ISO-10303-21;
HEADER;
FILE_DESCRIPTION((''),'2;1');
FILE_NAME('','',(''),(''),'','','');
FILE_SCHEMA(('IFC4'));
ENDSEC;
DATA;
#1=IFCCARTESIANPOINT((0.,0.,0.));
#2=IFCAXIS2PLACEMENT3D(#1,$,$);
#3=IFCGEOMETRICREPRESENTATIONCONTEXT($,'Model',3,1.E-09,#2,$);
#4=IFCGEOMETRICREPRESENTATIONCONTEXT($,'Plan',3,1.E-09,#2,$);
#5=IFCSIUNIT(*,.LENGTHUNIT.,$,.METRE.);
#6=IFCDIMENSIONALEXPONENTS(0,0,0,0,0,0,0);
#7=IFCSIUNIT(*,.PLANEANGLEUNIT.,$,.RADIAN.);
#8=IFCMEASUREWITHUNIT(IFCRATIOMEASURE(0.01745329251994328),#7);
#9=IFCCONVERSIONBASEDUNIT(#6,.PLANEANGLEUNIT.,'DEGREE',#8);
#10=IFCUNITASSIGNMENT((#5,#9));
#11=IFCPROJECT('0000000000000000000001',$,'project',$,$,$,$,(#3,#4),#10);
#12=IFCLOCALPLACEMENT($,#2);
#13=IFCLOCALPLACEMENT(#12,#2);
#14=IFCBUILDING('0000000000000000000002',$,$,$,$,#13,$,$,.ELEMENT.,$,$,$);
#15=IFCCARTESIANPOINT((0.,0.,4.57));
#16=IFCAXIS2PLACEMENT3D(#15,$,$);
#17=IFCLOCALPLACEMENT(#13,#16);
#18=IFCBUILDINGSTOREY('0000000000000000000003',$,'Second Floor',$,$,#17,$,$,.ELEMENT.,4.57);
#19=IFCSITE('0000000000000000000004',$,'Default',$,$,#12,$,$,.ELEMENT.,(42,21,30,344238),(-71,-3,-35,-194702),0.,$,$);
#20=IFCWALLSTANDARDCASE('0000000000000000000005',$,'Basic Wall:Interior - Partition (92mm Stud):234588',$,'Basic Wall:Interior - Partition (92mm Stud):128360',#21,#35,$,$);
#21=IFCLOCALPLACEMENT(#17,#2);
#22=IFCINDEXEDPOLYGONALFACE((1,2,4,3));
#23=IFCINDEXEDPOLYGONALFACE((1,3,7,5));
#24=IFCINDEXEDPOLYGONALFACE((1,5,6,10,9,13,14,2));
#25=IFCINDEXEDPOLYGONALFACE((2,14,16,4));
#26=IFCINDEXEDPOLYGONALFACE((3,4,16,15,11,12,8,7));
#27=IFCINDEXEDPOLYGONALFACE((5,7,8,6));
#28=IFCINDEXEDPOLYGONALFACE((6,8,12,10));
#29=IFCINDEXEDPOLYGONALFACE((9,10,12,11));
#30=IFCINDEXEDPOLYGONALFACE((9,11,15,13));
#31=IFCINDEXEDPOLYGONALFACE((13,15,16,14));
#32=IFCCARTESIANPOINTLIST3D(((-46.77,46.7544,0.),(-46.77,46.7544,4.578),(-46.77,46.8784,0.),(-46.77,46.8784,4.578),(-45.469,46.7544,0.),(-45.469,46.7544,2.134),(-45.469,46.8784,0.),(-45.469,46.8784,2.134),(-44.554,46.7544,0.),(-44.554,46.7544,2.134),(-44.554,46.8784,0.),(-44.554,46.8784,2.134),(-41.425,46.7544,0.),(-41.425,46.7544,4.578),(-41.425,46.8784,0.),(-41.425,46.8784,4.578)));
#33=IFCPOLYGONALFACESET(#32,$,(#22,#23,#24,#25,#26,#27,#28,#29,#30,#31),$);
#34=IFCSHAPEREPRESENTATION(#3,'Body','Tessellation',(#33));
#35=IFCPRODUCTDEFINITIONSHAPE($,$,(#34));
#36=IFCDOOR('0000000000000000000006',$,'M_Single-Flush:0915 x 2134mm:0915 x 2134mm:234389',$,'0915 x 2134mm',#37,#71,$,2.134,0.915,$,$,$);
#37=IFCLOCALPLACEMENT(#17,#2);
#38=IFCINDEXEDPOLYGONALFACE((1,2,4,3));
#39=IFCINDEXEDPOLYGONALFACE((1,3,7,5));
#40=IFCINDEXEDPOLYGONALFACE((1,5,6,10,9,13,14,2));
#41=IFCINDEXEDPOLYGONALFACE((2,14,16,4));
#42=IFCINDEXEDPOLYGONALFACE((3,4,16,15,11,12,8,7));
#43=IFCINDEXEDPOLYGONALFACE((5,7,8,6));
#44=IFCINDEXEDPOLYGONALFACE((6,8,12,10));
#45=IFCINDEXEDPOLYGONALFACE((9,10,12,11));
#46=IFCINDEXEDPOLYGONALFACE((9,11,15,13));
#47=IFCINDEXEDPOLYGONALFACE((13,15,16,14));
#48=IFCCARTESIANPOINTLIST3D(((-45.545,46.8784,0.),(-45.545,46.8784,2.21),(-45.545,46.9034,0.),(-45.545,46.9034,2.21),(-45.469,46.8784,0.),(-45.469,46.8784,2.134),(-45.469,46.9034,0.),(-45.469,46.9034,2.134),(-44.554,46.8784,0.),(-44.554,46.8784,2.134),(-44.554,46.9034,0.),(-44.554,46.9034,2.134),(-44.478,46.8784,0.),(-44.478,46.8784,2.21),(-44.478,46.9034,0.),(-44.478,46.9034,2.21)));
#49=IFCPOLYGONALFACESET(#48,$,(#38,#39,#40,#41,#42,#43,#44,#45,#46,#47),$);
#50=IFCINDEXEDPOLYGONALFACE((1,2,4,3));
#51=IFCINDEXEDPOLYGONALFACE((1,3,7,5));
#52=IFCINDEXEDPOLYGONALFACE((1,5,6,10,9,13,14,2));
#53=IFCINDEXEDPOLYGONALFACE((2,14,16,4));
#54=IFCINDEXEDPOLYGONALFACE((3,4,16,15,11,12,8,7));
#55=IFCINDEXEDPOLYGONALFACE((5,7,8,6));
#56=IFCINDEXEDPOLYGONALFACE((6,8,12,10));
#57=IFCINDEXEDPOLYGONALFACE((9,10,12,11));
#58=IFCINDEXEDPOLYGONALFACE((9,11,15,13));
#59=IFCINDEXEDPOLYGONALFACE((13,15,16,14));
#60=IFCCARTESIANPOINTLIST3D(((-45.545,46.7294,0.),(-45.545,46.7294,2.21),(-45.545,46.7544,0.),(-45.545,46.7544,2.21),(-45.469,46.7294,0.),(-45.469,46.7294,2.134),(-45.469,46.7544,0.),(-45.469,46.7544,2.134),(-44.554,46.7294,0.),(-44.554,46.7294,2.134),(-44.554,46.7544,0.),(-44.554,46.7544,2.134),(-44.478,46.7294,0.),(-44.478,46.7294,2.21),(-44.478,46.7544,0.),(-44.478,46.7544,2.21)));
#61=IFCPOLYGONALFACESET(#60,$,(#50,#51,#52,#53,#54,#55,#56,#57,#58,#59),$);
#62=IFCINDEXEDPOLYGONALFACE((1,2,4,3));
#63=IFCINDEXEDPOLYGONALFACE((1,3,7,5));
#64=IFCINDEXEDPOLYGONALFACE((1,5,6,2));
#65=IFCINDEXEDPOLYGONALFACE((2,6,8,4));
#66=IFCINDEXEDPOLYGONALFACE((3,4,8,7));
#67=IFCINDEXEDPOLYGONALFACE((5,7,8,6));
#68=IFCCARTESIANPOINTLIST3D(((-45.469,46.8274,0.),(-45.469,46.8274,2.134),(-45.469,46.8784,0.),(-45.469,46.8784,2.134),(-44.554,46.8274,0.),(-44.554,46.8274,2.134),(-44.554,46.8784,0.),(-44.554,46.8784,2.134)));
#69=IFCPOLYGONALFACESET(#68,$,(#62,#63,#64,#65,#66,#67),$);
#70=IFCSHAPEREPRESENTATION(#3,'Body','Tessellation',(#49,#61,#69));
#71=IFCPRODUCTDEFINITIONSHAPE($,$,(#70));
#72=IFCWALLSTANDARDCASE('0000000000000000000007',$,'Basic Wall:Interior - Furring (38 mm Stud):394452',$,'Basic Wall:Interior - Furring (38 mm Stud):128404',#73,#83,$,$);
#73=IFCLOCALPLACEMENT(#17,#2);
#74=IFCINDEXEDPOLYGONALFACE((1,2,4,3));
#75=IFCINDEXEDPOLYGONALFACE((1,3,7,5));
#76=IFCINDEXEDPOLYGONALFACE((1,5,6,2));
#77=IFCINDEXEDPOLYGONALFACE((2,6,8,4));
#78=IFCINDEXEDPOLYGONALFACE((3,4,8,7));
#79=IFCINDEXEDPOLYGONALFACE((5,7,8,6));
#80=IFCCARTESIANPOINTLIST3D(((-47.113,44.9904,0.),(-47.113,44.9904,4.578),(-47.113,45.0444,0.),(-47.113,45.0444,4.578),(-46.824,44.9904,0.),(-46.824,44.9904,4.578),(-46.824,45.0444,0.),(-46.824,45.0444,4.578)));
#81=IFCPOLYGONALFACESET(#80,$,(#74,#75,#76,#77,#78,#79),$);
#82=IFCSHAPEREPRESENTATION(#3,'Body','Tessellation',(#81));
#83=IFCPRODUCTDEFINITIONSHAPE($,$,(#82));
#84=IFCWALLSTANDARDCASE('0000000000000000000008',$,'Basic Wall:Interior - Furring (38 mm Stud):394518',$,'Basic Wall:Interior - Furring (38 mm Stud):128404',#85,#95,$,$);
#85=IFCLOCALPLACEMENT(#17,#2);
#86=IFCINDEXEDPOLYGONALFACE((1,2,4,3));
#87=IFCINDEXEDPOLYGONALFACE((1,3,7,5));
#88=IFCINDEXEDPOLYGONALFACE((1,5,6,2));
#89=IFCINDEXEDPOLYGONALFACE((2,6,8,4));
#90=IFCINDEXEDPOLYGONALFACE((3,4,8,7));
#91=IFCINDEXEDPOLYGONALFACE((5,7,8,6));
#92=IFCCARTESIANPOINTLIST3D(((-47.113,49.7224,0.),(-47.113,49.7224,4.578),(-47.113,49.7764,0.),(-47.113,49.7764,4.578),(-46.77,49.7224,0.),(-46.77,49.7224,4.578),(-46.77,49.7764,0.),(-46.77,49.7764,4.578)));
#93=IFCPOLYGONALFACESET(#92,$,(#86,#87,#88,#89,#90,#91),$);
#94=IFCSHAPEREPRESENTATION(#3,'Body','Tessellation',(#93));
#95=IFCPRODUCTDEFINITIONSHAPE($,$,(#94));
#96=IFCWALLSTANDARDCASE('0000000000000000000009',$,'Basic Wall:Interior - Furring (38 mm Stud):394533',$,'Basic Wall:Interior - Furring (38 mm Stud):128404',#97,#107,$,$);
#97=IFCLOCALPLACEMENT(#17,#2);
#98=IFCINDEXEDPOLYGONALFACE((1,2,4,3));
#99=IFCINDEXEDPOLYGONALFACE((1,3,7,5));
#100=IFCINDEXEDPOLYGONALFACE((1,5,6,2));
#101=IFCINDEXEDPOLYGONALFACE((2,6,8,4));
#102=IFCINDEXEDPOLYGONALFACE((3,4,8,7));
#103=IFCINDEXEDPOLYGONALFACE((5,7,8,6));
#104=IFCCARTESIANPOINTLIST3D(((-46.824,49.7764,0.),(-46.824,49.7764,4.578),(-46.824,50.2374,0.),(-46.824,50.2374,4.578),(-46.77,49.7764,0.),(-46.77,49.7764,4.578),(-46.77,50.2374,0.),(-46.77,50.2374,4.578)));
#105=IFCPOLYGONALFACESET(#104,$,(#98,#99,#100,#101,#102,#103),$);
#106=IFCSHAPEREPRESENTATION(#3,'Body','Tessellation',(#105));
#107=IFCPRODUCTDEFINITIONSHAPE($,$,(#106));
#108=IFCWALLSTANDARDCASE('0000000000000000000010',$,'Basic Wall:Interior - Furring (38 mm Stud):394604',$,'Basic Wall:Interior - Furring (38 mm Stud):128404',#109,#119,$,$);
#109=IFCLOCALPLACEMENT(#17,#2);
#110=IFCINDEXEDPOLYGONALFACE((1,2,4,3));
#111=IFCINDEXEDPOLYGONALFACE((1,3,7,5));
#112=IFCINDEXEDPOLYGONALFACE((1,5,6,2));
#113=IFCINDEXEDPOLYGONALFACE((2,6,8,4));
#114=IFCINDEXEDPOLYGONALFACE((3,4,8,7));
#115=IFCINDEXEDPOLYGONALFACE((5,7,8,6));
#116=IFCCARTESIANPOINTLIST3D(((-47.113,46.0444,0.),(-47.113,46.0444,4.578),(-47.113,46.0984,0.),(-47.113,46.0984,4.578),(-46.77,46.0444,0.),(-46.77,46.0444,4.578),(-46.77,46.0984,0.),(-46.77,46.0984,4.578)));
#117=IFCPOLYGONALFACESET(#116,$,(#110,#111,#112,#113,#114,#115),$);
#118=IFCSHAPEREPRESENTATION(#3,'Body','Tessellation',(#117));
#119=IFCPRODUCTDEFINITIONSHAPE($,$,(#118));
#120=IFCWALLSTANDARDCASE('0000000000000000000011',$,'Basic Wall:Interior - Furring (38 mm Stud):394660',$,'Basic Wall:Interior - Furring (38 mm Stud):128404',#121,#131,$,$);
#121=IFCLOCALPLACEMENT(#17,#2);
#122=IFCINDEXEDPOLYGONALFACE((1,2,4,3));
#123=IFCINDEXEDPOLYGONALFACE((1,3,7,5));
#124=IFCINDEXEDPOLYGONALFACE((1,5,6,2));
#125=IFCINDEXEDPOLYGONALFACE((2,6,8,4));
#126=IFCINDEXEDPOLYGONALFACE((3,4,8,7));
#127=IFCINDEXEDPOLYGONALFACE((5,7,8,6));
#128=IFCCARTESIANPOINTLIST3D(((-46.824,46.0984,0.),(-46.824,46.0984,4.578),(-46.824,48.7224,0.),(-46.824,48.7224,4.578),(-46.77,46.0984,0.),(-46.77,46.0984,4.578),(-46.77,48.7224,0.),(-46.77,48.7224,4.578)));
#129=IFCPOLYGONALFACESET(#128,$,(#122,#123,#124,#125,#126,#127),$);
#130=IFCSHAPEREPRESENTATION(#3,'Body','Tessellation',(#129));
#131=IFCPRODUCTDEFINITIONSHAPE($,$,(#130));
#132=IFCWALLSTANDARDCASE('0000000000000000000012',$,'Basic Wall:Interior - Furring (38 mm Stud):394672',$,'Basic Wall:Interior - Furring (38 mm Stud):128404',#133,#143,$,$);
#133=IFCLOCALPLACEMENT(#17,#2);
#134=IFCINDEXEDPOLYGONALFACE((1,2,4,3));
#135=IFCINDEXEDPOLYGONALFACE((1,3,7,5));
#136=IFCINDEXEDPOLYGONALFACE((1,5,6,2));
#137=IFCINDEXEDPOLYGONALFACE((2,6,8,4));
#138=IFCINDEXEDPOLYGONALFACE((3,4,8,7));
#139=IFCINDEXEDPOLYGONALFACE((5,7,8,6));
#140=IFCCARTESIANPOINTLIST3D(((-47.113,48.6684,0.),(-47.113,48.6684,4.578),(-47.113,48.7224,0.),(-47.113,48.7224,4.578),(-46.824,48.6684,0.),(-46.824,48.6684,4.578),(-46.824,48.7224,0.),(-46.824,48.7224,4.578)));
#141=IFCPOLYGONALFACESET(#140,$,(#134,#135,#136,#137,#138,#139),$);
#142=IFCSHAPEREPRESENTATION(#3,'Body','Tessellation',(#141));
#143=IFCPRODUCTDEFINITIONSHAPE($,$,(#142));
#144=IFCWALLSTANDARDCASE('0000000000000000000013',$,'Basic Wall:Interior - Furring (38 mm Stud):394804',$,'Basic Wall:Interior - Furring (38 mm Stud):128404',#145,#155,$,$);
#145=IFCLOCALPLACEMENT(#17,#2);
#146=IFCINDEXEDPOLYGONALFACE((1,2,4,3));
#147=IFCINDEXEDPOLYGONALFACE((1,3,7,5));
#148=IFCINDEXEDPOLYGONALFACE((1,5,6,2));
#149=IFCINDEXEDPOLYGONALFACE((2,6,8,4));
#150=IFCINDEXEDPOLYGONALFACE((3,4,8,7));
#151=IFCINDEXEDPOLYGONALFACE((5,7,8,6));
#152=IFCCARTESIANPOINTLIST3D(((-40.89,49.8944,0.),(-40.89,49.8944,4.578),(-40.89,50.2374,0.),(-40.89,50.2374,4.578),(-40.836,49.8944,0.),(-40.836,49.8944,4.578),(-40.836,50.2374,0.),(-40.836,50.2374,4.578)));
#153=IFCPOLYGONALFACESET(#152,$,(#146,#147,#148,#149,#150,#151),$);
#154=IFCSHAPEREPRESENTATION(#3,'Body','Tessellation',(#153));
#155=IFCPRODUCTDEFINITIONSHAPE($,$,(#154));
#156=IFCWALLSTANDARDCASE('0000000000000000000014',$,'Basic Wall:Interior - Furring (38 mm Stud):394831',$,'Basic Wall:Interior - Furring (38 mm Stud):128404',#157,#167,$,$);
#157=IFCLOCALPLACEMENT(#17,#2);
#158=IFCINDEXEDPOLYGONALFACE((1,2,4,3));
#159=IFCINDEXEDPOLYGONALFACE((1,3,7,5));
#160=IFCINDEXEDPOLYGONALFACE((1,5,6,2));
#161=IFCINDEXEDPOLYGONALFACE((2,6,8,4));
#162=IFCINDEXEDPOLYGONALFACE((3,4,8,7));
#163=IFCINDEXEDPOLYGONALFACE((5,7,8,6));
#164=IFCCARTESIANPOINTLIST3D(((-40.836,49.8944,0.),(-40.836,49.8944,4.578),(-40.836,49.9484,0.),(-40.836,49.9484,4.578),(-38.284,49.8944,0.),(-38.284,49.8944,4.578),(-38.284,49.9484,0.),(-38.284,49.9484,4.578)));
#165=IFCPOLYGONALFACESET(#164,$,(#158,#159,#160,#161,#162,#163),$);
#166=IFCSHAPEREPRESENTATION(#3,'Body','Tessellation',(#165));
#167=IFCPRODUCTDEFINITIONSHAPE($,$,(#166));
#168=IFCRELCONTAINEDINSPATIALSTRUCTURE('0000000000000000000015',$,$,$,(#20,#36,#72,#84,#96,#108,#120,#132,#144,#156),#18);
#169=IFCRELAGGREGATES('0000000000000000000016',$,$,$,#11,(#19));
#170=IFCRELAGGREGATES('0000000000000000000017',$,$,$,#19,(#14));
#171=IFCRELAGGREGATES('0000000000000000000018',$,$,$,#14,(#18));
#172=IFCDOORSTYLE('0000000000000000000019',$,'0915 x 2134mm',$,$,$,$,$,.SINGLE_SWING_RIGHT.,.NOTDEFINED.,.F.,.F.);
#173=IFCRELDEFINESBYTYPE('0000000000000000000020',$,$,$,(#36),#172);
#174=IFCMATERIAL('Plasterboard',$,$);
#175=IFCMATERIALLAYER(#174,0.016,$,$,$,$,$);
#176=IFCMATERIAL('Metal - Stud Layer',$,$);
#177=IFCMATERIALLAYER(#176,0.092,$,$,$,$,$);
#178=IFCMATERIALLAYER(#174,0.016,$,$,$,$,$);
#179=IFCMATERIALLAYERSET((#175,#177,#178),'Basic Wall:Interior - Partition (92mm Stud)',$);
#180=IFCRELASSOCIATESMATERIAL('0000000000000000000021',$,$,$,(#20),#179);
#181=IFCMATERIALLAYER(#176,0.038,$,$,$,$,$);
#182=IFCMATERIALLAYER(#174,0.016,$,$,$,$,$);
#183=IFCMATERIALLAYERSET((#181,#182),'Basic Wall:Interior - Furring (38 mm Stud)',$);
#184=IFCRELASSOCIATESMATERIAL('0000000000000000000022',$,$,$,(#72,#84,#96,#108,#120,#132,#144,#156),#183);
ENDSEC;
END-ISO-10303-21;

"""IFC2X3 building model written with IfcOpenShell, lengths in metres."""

from ifc_helpers import new_model, entity, si_unit, converted_unit, frame, frame_2d, origin, origin_2d_with_axis, place, context, project, spatial, polyline, rectangle, outline, extrude, source, transform, mapped, material, layer, layer_set, layer_usage, type_object, type_shapes, element, fill, save


model = new_model("IFC2X3")

# Units and contexts
model_context = context("Model", 3, precision=1e-09, world=origin())
plan_context = context("Plan", 3, precision=1e-09, world=origin())
ifc_project = project(units=[si_unit("LENGTHUNIT", "METRE"), converted_unit("PLANEANGLEUNIT", "DEGREE", entity("IfcRatioMeasure", 0.01745329251994328), si_unit("PLANEANGLEUNIT", "RADIAN"), dimensions=[0, 0, 0, 0, 0, 0, 0])], contexts=[model_context, plan_context])

# Site, building, storey
site_placement = place(None, origin())
site = spatial("IfcSite", under=ifc_project, at=site_placement, Name="Default", CompositionType="ELEMENT", RefLatitude=(42, 21, 30, 344238), RefLongitude=(-71, -3, -35, -194702), RefElevation=0.0)
building_placement = place(site_placement, origin())
building = spatial("IfcBuilding", under=site, at=building_placement, CompositionType="ELEMENT")
storey_placement = place(building_placement, frame((0.0, 0.0, 4.57)))
storey = spatial("IfcBuildingStorey", under=building, at=storey_placement, Name="Second Floor", CompositionType="ELEMENT", Elevation=4.57)

# Shared definitions
ifc_material_1 = material(Name="Metal - Stud Layer")
ifc_material_2 = material(Name="Plasterboard")

# Shared definitions
ifc_layer_1 = layer(ifc_material_2, 0.016)
ifc_layer_2 = layer(ifc_material_1, 0.092)
ifc_layer_3 = layer(ifc_material_2, 0.016)
ifc_layer_set_1 = layer_set([ifc_layer_1, ifc_layer_2, ifc_layer_3], Name="Basic Wall:Interior - Partition (92mm Stud)")

# Wall, opening, door
door_style_1 = type_object("IfcDoorStyle", Name="0915 x 2134mm", ConstructionType="NOTDEFINED", OperationType="SINGLE_SWING_RIGHT", ParameterTakesPrecedence=False, Sizeable=False)
shared_shape_1 = source(origin(), model_context, "Body", "SweptSolid", [
    extrude(outline(polyline([(-0.5335, -1.124), (0.5335, -1.124), (0.5335, 1.086), (0.4575, 1.086), (0.4575, -1.048), (-0.4575, -1.048), (-0.4575, 1.086), (-0.5335, 1.086), (-0.5335, -1.124)])), frame((0.4575, 0.124, 1.086), z_axis=(0.0, 1.0, 0.0), x_axis=(1.0, 0.0, 0.0)), (0.0, 0.0, 1.0), 0.025),
    extrude(outline(polyline([(-1.124, -0.5335), (1.086, -0.5335), (1.086, -0.4575), (-1.048, -0.4575), (-1.048, 0.4575), (1.086, 0.4575), (1.086, 0.5335), (-1.124, 0.5335), (-1.124, -0.5335)])), frame((0.4575, -0.025, 1.086), z_axis=(0.0, 1.0, 0.0), x_axis=(0.0, 0.0, -1.0)), (0.0, 0.0, 1.0), 0.025),
    extrude(rectangle(XDim=0.051, YDim=0.915, at=origin_2d_with_axis()), frame((0.4575, 0.0985, 0.0), z_axis=(0.0, 0.0, 1.0), x_axis=(0.0, 1.0, 0.0)), (0.0, 0.0, 1.0), 2.134),
])
type_shapes(door_style_1, [shared_shape_1])
ifc_layer_usage_1 = layer_usage(ifc_layer_set_1, "AXIS2", "NEGATIVE", 0.062)
wall_1_placement = place(storey_placement, frame((-41.425, 46.8164, 0.0), z_axis=(0.0, 0.0, 1.0), x_axis=(-1.0, 0.0, 0.0)))
wall_1 = element("IfcWallStandardCase", 1, at=wall_1_placement, inside=storey, material=ifc_layer_usage_1, Name="Basic Wall:Interior - Partition (92mm Stud):234588", ObjectType="Basic Wall:Interior - Partition (92mm Stud):128360", context=model_context, shape_type="SweptSolid", body=[
    extrude(rectangle(XDim=5.345, YDim=0.124, at=frame_2d((2.6725, 0.0), x_axis=(-1.0, 0.0))), origin(), (0.0, 0.0, 1.0), 4.578),
])
opening_1_placement = place(wall_1_placement, frame((4.044, 0.062, 0.0)))
opening_1 = element("IfcOpeningElement", 2, at=opening_1_placement, cuts=wall_1, ObjectType="Opening", context=model_context, shape_type="SweptSolid", body=[
    extrude(rectangle(XDim=0.915, YDim=2.134, at=frame_2d((1.067, 0.4575), x_axis=(0.0, 1.0))), frame((0.0, 0.0, 0.0), z_axis=(0.0, -1.0, 0.0), x_axis=(0.0, 0.0, 1.0)), (0.0, 0.0, 1.0), 0.124),
])
door_1_placement = place(opening_1_placement, frame((0.0, 0.0, 0.0), z_axis=(0.0, 0.0, 1.0), x_axis=(-1.0, 0.0, 0.0)))
door_1 = element("IfcDoor", 3, at=door_1_placement, inside=storey, type_object=door_style_1, Name="M_Single-Flush:0915 x 2134mm:0915 x 2134mm:234389", ObjectType="0915 x 2134mm", OverallHeight=2.134, OverallWidth=0.915, context=model_context, shape_type="MappedRepresentation", body=[
    mapped(shared_shape_1, transform((0.0, 0.0, 0.0), scale=1.0)),
])
fill(opening_1, door_1)

# Walls
ifc_layer_4 = layer(ifc_material_1, 0.038)
ifc_layer_5 = layer(ifc_material_2, 0.016)
ifc_layer_set_2 = layer_set([ifc_layer_4, ifc_layer_5], Name="Basic Wall:Interior - Furring (38 mm Stud)")
ifc_layer_usage_2 = layer_usage(ifc_layer_set_2, "AXIS2", "NEGATIVE", 0.027)
wall_2_placement = place(storey_placement, frame((-46.824, 45.0174, 0.0), z_axis=(0.0, 0.0, 1.0), x_axis=(-1.0, 0.0, 0.0)))
element("IfcWallStandardCase", 4, at=wall_2_placement, inside=storey, material=ifc_layer_usage_2, Name="Basic Wall:Interior - Furring (38 mm Stud):394452", ObjectType="Basic Wall:Interior - Furring (38 mm Stud):128404", context=model_context, shape_type="SweptSolid", body=[
    extrude(rectangle(XDim=0.289, YDim=0.054, at=frame_2d((0.1445, 0.0), x_axis=(-1.0, 0.0))), origin(), (0.0, 0.0, 1.0), 4.578),
])
ifc_layer_usage_3 = layer_usage(ifc_layer_set_2, "AXIS2", "NEGATIVE", 0.027)
wall_3_placement = place(storey_placement, frame((-47.113, 49.7494, 0.0)))
element("IfcWallStandardCase", 5, at=wall_3_placement, inside=storey, material=ifc_layer_usage_3, Name="Basic Wall:Interior - Furring (38 mm Stud):394518", ObjectType="Basic Wall:Interior - Furring (38 mm Stud):128404", context=model_context, shape_type="SweptSolid", body=[
    extrude(rectangle(XDim=0.343, YDim=0.054, at=frame_2d((0.1715, 0.0), x_axis=(-1.0, 0.0))), origin(), (0.0, 0.0, 1.0), 4.578),
])
ifc_layer_usage_4 = layer_usage(ifc_layer_set_2, "AXIS2", "NEGATIVE", 0.027)
wall_4_placement = place(storey_placement, frame((-46.797, 49.7764, 0.0), z_axis=(0.0, 0.0, 1.0), x_axis=(0.0, 1.0, 0.0)))
element("IfcWallStandardCase", 6, at=wall_4_placement, inside=storey, material=ifc_layer_usage_4, Name="Basic Wall:Interior - Furring (38 mm Stud):394533", ObjectType="Basic Wall:Interior - Furring (38 mm Stud):128404", context=model_context, shape_type="SweptSolid", body=[
    extrude(rectangle(XDim=0.461, YDim=0.054, at=frame_2d((0.2305, 0.0), x_axis=(-1.0, 0.0))), origin(), (0.0, 0.0, 1.0), 4.578),
])
ifc_layer_usage_5 = layer_usage(ifc_layer_set_2, "AXIS2", "NEGATIVE", 0.027)
wall_5_placement = place(storey_placement, frame((-47.113, 46.0714, 0.0)))
element("IfcWallStandardCase", 7, at=wall_5_placement, inside=storey, material=ifc_layer_usage_5, Name="Basic Wall:Interior - Furring (38 mm Stud):394604", ObjectType="Basic Wall:Interior - Furring (38 mm Stud):128404", context=model_context, shape_type="SweptSolid", body=[
    extrude(rectangle(XDim=0.343, YDim=0.054, at=frame_2d((0.1715, 0.0), x_axis=(-1.0, 0.0))), origin(), (0.0, 0.0, 1.0), 4.578),
])
ifc_layer_usage_6 = layer_usage(ifc_layer_set_2, "AXIS2", "NEGATIVE", 0.027)
wall_6_placement = place(storey_placement, frame((-46.797, 46.0984, 0.0), z_axis=(0.0, 0.0, 1.0), x_axis=(0.0, 1.0, 0.0)))
element("IfcWallStandardCase", 8, at=wall_6_placement, inside=storey, material=ifc_layer_usage_6, Name="Basic Wall:Interior - Furring (38 mm Stud):394660", ObjectType="Basic Wall:Interior - Furring (38 mm Stud):128404", context=model_context, shape_type="SweptSolid", body=[
    extrude(rectangle(XDim=2.624, YDim=0.054, at=frame_2d((1.312, 0.0), x_axis=(-1.0, 0.0))), origin(), (0.0, 0.0, 1.0), 4.578),
])
ifc_layer_usage_7 = layer_usage(ifc_layer_set_2, "AXIS2", "NEGATIVE", 0.027)
wall_7_placement = place(storey_placement, frame((-46.824, 48.6954, 0.0), z_axis=(0.0, 0.0, 1.0), x_axis=(-1.0, 0.0, 0.0)))
element("IfcWallStandardCase", 9, at=wall_7_placement, inside=storey, material=ifc_layer_usage_7, Name="Basic Wall:Interior - Furring (38 mm Stud):394672", ObjectType="Basic Wall:Interior - Furring (38 mm Stud):128404", context=model_context, shape_type="SweptSolid", body=[
    extrude(rectangle(XDim=0.289, YDim=0.054, at=frame_2d((0.1445, 0.0), x_axis=(-1.0, 0.0))), origin(), (0.0, 0.0, 1.0), 4.578),
])
ifc_layer_usage_8 = layer_usage(ifc_layer_set_2, "AXIS2", "NEGATIVE", 0.027)
wall_8_placement = place(storey_placement, frame((-40.863, 50.2374, 0.0), z_axis=(0.0, 0.0, 1.0), x_axis=(0.0, -1.0, 0.0)))
element("IfcWallStandardCase", 10, at=wall_8_placement, inside=storey, material=ifc_layer_usage_8, Name="Basic Wall:Interior - Furring (38 mm Stud):394804", ObjectType="Basic Wall:Interior - Furring (38 mm Stud):128404", context=model_context, shape_type="SweptSolid", body=[
    extrude(rectangle(XDim=0.343, YDim=0.054, at=frame_2d((0.1715, 0.0), x_axis=(-1.0, 0.0))), origin(), (0.0, 0.0, 1.0), 4.578),
])
ifc_layer_usage_9 = layer_usage(ifc_layer_set_2, "AXIS2", "NEGATIVE", 0.027)
wall_9_placement = place(storey_placement, frame((-40.836, 49.9214, 0.0)))
element("IfcWallStandardCase", 11, at=wall_9_placement, inside=storey, material=ifc_layer_usage_9, Name="Basic Wall:Interior - Furring (38 mm Stud):394831", ObjectType="Basic Wall:Interior - Furring (38 mm Stud):128404", context=model_context, shape_type="SweptSolid", body=[
    extrude(rectangle(XDim=2.552, YDim=0.054, at=frame_2d((1.276, 0.0), x_axis=(-1.0, 0.0))), origin(), (0.0, 0.0, 1.0), 4.578),
])

save(model, "model.ifc")
